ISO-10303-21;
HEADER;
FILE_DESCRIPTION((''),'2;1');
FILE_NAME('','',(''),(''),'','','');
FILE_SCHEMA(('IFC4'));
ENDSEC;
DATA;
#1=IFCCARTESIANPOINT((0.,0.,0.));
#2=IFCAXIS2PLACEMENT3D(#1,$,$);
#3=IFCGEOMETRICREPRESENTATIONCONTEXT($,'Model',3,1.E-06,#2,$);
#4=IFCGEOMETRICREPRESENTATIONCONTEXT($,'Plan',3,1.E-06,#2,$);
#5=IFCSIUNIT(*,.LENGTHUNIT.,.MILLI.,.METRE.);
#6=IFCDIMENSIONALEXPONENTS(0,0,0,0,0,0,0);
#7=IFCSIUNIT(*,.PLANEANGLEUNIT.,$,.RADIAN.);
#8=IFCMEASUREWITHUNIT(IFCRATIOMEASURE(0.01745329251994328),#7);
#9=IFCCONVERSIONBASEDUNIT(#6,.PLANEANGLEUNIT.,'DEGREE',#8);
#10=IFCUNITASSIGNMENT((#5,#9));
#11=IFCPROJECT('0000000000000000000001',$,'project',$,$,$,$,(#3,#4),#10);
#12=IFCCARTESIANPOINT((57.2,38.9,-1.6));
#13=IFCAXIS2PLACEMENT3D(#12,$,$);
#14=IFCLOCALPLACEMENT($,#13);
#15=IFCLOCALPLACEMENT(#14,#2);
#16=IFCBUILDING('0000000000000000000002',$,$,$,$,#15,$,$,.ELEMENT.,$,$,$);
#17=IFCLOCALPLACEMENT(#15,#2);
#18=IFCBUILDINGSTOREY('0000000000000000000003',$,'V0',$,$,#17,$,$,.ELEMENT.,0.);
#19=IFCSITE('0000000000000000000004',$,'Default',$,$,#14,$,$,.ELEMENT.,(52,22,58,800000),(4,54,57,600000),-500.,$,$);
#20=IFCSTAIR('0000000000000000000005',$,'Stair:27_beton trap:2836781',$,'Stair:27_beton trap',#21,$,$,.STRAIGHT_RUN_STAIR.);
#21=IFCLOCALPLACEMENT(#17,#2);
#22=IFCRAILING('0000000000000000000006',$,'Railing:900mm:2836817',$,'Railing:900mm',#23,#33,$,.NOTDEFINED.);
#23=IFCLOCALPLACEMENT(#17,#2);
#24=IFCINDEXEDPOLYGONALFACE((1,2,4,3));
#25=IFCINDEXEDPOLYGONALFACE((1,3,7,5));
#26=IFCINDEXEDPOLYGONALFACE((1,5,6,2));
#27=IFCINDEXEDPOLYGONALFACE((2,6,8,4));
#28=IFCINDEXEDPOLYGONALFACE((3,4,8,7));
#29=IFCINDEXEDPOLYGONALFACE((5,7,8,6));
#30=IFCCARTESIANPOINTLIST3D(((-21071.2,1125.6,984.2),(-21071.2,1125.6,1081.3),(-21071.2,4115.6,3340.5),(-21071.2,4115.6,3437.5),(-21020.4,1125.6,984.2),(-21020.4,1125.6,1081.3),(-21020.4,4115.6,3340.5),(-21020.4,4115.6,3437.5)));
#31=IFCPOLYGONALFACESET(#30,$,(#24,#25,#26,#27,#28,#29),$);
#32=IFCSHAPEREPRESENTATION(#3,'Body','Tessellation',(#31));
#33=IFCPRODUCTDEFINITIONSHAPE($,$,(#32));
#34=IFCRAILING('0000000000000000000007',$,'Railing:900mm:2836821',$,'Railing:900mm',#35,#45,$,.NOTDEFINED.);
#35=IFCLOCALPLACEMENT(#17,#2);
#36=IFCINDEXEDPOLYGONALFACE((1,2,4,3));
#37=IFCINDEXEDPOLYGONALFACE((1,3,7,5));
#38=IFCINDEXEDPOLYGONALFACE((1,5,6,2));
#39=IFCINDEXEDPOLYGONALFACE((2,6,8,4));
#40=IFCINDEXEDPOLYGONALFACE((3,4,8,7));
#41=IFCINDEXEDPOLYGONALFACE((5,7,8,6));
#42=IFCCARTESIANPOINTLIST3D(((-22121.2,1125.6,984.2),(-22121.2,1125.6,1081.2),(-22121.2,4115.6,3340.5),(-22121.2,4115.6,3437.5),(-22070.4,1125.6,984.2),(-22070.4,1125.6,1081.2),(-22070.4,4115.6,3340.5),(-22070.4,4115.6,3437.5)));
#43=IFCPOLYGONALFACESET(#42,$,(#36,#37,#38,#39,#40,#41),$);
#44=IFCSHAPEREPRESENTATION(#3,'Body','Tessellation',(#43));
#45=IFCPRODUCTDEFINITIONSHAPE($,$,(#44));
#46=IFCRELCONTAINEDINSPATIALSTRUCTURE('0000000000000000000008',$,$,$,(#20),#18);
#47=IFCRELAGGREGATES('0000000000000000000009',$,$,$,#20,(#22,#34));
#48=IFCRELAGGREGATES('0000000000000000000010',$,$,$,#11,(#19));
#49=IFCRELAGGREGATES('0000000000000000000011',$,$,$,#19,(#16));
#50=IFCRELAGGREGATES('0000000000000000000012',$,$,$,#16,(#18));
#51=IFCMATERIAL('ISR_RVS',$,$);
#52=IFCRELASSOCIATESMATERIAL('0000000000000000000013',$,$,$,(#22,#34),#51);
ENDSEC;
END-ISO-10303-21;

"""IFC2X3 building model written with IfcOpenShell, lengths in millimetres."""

from ifc_helpers import new_model, entity, si_unit, converted_unit, frame, origin, origin_2d_with_axis, place, context, project, spatial, rectangle, extrude, material, element, aggregate, save


model = new_model("IFC2X3")

# Units and contexts
model_context = context("Model", 3, precision=1e-06, world=origin())
plan_context = context("Plan", 3, precision=1e-06, world=origin())
ifc_project = project(units=[si_unit("LENGTHUNIT", "METRE", prefix="MILLI"), converted_unit("PLANEANGLEUNIT", "DEGREE", entity("IfcRatioMeasure", 0.01745329251994328), si_unit("PLANEANGLEUNIT", "RADIAN"), dimensions=[0, 0, 0, 0, 0, 0, 0])], contexts=[model_context, plan_context])

# Site, building, storey
site_placement = place(None, frame((57.2, 38.9, -1.6)))
site = spatial("IfcSite", under=ifc_project, at=site_placement, Name="Default", CompositionType="ELEMENT", RefLatitude=(52, 22, 58, 800000), RefLongitude=(4, 54, 57, 600000), RefElevation=-500.0)
building_placement = place(site_placement, origin())
building = spatial("IfcBuilding", under=site, at=building_placement, CompositionType="ELEMENT")
storey_placement = place(building_placement, origin())
storey = spatial("IfcBuildingStorey", under=building, at=storey_placement, Name="V0", CompositionType="ELEMENT", Elevation=0.0)

# Stair, railings
stair_placement = place(storey_placement, origin())
stair = element("IfcStair", 1, at=stair_placement, inside=storey, Name="Stair:27_beton trap:2836781", ObjectType="Stair:27_beton trap", ShapeType="STRAIGHT_RUN_STAIR")
ifc_material_1 = material(Name="ISR_RVS")
railing_1_placement = place(storey_placement, origin())
railing_1 = element("IfcRailing", 2, at=railing_1_placement, material=ifc_material_1, Name="Railing:900mm:2836817", ObjectType="Railing:900mm", PredefinedType="NOTDEFINED", context=model_context, shape_type="SweptSolid", body=[
    extrude(rectangle(XDim=3806.8, YDim=50.8, at=origin_2d_with_axis()), frame((-21045.8, 2620.6, 2162.4), z_axis=(0.0, -0.618952, 0.785429), x_axis=(0.0, 0.785429, 0.618952)), (0.618952, 0.0, 0.785429), 97.0),
])
railing_2_placement = place(storey_placement, origin())
railing_2 = element("IfcRailing", 3, at=railing_2_placement, material=ifc_material_1, Name="Railing:900mm:2836821", ObjectType="Railing:900mm", PredefinedType="NOTDEFINED", context=model_context, shape_type="SweptSolid", body=[
    extrude(rectangle(XDim=3806.8, YDim=50.8, at=origin_2d_with_axis()), frame((-22095.8, 2620.6, 2162.4), z_axis=(0.0, -0.618952, 0.785429), x_axis=(0.0, 0.785429, 0.618952)), (0.618952, 0.0, 0.785429), 97.0),
])
aggregate(stair, [railing_1, railing_2])

save(model, "model.ifc")
